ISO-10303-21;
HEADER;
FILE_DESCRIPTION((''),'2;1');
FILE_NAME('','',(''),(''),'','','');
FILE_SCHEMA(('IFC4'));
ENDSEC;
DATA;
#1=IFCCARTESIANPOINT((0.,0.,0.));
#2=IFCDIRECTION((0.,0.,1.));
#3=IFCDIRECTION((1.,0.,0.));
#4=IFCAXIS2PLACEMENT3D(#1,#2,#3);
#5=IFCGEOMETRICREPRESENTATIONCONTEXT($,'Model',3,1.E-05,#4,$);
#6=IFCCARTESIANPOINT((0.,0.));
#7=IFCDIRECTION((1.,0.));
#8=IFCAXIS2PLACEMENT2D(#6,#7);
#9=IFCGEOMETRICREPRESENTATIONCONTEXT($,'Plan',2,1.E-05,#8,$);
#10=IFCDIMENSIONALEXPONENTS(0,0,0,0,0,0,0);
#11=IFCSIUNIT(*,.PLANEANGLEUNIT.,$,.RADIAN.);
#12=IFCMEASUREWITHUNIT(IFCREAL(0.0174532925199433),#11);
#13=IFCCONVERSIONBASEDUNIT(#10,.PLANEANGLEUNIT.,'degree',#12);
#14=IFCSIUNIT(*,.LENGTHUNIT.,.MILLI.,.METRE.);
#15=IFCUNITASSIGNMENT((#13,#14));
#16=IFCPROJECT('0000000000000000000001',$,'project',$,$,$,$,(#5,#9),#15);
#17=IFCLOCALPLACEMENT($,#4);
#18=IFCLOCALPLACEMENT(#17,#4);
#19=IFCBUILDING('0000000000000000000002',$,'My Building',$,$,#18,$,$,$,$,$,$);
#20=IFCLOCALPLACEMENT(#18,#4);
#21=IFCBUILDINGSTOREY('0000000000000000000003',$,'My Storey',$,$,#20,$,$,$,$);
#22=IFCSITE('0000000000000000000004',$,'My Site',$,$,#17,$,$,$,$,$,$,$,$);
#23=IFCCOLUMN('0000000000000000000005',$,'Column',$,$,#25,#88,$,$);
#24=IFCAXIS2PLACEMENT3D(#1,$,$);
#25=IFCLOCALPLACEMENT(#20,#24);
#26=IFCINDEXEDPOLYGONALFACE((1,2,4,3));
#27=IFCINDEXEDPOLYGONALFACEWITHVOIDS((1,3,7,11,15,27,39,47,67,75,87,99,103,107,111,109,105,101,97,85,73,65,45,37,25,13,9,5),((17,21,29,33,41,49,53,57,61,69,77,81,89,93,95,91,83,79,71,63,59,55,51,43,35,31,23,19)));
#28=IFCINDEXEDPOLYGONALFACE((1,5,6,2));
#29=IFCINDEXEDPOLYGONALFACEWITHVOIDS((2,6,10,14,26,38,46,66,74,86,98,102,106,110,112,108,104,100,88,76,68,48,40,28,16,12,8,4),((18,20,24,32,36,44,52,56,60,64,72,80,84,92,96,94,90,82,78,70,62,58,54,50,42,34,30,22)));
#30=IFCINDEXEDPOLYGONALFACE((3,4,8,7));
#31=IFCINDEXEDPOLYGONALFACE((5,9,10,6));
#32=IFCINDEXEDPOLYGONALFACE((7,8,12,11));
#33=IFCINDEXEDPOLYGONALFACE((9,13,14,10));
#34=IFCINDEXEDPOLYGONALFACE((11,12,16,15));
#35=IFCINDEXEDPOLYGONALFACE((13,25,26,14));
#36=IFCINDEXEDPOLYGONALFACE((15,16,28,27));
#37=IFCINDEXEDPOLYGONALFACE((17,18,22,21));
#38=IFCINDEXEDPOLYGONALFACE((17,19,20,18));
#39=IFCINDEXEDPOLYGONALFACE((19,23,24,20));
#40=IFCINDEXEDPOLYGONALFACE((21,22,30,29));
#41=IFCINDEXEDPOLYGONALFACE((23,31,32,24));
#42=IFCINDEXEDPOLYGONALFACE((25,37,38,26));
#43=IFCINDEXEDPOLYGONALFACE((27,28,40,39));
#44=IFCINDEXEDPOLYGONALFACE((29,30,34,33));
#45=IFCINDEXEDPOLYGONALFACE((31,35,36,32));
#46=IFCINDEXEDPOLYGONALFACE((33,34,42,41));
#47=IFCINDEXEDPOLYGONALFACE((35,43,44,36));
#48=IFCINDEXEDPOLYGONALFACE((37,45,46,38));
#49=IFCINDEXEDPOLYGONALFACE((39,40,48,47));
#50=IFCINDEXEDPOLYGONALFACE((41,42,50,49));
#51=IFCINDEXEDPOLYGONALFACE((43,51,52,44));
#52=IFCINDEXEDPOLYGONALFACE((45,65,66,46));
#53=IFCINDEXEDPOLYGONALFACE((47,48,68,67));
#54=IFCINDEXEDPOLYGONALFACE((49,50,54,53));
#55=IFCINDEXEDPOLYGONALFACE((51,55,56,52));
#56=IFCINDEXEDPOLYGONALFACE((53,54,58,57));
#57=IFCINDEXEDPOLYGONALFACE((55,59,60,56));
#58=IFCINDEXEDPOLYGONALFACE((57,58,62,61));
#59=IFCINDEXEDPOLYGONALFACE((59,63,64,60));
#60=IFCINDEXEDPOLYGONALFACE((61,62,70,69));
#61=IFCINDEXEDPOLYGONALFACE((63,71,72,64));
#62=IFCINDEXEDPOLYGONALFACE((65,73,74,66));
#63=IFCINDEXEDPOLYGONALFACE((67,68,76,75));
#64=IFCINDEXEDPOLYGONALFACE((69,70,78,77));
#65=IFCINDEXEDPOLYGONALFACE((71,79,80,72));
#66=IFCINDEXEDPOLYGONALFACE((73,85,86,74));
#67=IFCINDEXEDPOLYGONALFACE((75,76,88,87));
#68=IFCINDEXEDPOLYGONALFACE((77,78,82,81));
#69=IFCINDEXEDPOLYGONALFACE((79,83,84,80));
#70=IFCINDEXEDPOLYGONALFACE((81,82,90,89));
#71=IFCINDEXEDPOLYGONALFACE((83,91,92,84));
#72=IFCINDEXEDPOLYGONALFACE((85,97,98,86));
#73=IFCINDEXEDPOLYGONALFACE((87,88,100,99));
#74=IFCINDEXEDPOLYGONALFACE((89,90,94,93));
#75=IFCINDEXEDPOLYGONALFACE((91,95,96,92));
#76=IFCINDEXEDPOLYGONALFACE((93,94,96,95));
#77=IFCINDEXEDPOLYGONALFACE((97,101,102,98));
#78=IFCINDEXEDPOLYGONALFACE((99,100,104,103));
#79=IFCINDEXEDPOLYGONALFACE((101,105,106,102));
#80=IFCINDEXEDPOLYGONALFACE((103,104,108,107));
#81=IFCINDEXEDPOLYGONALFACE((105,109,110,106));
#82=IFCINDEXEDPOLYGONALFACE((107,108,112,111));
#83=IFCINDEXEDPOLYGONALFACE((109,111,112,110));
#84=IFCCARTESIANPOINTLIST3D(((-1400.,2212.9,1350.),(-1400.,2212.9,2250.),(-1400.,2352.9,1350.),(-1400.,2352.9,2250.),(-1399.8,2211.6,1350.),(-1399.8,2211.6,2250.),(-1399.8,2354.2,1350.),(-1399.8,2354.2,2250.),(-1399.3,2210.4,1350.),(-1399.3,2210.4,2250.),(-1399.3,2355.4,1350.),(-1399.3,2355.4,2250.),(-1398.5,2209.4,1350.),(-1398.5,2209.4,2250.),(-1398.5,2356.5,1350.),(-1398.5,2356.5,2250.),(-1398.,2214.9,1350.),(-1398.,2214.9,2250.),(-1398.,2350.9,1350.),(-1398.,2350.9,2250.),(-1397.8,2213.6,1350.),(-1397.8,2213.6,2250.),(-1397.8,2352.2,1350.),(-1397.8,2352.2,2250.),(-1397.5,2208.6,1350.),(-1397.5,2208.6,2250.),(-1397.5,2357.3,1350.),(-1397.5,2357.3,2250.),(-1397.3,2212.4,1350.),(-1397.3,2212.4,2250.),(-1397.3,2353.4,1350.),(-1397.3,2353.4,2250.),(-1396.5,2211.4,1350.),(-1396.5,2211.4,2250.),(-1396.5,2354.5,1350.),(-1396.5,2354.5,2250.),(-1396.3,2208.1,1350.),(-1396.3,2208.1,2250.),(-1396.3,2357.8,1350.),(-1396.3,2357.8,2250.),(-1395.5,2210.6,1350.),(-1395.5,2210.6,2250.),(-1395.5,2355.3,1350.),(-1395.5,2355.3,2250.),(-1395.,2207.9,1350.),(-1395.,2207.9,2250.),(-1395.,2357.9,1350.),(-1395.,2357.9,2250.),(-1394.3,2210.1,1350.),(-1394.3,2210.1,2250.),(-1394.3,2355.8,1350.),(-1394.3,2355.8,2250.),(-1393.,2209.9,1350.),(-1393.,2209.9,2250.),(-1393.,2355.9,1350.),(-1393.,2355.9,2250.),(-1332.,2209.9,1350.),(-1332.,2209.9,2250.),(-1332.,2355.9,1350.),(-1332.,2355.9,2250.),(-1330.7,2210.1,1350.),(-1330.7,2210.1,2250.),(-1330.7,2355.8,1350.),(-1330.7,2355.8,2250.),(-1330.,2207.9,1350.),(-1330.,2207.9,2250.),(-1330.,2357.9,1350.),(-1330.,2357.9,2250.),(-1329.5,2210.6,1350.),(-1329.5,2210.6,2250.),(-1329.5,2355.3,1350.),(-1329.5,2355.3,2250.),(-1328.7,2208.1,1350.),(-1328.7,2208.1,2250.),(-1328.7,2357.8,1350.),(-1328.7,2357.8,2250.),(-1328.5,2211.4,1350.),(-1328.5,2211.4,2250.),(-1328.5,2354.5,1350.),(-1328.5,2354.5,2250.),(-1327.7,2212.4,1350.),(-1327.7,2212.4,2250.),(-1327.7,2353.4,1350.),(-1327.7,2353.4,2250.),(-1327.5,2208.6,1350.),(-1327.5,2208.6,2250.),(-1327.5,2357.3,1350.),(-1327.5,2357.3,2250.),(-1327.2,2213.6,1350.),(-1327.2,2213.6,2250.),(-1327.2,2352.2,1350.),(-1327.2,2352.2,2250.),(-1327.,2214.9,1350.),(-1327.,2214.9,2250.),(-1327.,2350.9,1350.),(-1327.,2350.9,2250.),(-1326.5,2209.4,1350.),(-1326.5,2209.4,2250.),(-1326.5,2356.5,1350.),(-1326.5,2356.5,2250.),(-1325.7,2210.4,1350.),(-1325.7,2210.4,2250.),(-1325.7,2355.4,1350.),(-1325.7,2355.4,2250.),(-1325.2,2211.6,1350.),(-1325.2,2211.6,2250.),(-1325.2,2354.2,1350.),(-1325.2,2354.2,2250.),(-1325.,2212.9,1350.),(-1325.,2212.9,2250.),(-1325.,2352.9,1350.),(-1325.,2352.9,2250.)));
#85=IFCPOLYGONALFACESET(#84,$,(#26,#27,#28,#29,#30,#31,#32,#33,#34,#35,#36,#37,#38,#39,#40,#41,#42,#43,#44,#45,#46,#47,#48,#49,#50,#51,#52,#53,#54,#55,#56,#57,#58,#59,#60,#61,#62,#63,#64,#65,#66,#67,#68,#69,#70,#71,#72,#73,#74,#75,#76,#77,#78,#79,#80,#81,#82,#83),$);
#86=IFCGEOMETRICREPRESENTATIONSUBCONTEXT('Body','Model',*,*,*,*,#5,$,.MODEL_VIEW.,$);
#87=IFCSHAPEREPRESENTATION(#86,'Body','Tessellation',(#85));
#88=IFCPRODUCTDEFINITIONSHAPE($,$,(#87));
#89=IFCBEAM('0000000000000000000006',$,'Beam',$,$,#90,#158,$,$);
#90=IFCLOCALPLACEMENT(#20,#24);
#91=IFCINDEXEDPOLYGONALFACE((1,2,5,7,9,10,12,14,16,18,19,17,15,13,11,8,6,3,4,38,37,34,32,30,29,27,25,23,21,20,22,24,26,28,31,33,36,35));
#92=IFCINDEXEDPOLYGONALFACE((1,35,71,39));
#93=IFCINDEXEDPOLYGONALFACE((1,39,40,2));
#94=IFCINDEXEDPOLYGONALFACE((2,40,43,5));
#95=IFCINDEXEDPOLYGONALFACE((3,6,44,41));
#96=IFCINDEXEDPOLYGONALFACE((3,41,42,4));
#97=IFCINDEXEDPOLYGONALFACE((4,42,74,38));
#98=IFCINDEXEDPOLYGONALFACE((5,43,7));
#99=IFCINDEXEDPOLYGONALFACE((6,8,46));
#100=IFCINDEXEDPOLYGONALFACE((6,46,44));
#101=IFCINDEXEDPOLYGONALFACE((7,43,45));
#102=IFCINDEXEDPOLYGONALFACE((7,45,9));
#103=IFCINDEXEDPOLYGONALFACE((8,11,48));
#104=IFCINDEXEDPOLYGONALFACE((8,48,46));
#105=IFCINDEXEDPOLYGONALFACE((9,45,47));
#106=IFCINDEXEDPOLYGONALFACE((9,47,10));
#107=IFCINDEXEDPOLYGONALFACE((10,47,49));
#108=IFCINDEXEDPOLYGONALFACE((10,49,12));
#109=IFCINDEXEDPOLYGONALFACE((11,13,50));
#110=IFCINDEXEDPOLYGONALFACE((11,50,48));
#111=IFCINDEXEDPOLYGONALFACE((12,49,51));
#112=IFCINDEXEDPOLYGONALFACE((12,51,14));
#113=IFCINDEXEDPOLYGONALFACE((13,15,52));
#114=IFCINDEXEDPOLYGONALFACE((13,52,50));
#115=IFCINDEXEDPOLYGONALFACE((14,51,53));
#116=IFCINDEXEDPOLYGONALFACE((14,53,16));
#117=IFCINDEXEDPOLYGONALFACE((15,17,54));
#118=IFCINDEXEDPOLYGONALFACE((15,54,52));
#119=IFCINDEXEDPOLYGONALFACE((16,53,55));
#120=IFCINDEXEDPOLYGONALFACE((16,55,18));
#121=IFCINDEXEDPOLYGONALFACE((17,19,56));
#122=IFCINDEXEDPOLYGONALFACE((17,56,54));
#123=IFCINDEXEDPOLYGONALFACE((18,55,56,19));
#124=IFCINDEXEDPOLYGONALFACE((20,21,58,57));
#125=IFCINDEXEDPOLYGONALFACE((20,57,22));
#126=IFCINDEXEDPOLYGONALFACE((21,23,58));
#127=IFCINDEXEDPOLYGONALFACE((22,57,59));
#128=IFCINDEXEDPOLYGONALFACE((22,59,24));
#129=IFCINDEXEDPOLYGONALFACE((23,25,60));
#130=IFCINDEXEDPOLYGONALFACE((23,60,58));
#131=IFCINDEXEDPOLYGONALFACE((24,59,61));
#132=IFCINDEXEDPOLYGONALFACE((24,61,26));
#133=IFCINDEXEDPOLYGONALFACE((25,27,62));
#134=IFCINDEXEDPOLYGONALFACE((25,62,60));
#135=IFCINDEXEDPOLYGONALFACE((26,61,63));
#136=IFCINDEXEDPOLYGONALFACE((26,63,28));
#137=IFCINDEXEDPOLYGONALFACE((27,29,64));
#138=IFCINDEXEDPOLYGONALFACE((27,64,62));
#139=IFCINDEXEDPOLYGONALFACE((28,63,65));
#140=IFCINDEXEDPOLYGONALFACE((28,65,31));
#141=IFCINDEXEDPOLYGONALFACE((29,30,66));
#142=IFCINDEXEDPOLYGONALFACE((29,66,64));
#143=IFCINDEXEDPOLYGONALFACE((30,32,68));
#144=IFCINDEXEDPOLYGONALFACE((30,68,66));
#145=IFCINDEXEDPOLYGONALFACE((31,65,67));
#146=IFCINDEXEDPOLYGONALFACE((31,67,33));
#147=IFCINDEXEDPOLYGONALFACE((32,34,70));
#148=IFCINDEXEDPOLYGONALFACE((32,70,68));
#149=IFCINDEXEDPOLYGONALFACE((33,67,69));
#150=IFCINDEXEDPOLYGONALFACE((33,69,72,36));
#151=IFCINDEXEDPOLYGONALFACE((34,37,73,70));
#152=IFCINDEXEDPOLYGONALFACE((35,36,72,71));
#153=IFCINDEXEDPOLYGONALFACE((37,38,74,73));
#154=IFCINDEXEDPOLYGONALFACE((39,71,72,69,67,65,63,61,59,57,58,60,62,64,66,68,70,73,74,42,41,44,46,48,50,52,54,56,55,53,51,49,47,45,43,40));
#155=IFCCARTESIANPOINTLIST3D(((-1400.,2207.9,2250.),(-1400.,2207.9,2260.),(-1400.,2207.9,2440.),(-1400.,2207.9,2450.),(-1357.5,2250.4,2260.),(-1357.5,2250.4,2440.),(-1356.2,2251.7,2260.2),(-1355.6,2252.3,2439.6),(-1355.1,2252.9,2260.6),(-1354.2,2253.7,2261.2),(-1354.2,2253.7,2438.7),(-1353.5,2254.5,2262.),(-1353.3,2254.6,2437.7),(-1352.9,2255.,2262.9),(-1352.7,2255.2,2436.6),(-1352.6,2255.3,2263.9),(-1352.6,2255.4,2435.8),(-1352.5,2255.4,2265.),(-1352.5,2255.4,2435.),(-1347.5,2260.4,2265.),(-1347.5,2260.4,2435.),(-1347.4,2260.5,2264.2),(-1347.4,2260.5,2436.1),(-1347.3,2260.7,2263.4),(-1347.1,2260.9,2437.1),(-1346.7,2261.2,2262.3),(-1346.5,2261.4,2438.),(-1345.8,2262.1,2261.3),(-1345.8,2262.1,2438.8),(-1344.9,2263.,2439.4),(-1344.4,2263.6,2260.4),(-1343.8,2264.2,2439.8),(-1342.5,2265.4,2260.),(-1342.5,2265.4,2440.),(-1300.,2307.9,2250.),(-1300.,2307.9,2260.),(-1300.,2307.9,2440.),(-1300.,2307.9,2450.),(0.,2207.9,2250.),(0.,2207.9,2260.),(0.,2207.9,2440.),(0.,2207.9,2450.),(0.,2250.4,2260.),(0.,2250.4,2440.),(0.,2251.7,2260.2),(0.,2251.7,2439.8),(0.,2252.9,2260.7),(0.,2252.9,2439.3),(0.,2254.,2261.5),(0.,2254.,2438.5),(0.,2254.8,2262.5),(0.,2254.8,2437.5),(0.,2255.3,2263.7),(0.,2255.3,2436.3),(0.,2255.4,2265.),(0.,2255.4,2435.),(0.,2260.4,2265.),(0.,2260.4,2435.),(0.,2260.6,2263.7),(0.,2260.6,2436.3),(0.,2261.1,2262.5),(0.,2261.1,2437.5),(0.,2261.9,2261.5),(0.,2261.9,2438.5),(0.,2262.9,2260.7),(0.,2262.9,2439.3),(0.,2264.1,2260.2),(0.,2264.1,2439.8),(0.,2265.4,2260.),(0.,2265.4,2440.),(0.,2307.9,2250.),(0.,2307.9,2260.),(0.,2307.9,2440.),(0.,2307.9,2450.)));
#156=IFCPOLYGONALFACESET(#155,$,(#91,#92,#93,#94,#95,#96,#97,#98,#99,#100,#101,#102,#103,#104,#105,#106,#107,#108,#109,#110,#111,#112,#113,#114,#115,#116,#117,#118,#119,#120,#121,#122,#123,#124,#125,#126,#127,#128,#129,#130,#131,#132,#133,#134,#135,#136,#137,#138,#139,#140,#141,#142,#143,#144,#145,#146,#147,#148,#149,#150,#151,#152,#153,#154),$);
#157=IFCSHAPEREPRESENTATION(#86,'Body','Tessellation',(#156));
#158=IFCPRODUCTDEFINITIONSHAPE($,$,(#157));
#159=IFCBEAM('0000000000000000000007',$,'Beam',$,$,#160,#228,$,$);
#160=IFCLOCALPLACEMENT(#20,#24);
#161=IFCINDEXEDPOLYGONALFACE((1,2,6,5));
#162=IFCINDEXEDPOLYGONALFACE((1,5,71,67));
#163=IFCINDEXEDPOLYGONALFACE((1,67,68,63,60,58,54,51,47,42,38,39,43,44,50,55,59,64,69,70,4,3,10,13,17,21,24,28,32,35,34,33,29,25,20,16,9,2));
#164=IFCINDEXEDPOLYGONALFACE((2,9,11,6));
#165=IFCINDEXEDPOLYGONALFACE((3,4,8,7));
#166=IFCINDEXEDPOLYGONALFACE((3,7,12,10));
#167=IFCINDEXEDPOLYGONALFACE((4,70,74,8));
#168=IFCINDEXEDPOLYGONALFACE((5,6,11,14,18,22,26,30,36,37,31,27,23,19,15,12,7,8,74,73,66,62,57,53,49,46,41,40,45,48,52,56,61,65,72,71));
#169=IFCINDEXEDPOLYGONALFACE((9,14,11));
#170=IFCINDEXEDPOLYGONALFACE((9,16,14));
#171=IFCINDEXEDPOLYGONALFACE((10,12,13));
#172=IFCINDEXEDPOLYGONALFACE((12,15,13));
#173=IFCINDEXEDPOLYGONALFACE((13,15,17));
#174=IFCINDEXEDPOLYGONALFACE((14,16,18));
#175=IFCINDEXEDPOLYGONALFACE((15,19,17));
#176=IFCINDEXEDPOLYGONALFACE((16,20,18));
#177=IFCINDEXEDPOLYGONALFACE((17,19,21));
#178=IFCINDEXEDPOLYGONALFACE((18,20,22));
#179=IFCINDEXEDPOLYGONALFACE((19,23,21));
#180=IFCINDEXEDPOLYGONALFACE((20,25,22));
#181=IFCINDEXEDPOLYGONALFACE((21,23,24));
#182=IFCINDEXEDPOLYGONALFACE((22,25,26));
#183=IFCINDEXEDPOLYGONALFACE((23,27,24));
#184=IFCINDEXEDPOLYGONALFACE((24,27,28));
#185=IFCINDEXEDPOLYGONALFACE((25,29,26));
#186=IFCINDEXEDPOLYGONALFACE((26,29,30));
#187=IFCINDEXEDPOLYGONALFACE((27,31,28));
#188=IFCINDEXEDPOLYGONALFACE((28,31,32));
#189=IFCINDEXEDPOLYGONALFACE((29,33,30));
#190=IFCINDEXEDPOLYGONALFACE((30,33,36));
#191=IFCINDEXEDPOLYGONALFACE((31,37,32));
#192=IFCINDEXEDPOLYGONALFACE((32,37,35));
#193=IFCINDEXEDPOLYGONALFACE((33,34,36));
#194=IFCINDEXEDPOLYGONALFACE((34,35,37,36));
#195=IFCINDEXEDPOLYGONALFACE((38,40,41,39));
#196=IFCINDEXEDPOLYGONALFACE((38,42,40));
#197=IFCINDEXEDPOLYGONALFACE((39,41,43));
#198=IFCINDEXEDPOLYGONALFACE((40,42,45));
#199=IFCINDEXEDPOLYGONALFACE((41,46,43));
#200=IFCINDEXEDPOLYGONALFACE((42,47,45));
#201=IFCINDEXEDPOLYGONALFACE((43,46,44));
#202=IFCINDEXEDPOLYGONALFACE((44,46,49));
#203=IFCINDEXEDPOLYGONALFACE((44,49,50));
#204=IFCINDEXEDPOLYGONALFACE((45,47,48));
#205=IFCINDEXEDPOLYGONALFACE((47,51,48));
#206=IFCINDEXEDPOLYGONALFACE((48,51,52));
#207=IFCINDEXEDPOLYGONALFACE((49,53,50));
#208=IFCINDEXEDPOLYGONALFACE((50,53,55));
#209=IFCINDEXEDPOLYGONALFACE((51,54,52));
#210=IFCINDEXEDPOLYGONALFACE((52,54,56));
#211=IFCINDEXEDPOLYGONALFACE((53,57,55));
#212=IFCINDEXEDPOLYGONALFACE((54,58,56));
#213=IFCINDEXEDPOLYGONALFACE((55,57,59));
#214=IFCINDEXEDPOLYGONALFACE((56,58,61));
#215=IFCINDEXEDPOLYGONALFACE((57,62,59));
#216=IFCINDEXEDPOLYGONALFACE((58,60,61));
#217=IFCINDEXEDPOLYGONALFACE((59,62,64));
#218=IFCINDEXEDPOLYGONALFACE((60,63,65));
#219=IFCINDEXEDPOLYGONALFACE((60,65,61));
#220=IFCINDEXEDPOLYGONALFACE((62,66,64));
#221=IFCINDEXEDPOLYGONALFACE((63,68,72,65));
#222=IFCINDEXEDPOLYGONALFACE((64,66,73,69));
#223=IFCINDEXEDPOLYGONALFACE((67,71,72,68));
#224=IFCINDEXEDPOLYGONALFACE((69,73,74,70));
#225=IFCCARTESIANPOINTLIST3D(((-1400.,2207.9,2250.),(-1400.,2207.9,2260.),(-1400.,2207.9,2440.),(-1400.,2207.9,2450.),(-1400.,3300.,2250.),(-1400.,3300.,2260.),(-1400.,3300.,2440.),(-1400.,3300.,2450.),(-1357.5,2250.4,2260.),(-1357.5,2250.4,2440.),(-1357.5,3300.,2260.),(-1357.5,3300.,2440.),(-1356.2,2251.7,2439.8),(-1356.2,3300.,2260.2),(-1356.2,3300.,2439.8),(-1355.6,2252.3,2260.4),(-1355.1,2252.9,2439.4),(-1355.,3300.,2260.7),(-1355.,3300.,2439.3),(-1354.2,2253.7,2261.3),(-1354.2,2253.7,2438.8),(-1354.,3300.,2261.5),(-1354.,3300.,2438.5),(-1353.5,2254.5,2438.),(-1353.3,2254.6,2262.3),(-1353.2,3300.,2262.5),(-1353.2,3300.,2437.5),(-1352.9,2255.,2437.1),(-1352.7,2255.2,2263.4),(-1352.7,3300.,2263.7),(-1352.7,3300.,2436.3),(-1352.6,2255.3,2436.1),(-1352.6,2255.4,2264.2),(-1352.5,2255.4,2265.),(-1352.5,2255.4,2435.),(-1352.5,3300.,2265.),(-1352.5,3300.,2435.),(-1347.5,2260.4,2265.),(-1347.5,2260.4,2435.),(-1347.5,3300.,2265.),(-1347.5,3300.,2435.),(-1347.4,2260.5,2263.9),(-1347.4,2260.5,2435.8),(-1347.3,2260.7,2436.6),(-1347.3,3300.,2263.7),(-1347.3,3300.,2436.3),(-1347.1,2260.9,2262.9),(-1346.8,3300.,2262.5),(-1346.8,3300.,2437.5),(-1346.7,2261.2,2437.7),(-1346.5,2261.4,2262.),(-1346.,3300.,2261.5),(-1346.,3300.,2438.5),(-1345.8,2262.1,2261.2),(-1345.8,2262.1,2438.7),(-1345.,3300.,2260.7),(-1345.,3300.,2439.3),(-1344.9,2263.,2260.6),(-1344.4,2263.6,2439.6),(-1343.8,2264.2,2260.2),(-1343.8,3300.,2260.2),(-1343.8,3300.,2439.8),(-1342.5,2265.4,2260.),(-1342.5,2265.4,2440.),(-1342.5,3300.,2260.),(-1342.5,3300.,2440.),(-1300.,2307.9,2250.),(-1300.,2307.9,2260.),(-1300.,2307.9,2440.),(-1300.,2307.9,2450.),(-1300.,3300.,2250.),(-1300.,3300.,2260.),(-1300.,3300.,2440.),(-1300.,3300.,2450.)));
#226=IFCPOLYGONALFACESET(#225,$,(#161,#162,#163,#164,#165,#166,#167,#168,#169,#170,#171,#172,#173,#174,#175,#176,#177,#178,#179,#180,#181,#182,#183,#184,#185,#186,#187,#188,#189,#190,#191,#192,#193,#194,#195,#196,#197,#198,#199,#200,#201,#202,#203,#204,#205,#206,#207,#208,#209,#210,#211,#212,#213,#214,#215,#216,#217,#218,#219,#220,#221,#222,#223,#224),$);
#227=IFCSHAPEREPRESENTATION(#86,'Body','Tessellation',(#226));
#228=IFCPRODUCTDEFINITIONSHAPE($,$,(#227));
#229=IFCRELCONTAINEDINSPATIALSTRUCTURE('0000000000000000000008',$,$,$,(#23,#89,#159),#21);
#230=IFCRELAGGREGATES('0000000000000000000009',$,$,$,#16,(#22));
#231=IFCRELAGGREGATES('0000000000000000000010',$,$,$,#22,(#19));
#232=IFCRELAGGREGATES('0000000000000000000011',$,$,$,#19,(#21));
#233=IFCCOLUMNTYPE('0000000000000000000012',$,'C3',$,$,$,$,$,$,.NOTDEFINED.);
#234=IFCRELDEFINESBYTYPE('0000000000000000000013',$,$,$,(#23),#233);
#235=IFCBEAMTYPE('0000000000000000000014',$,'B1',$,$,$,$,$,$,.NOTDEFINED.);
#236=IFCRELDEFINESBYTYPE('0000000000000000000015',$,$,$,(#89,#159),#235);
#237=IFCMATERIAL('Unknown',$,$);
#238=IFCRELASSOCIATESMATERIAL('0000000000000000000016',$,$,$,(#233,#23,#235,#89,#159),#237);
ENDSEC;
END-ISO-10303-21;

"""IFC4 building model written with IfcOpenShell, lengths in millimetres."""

from ifc_helpers import new_model, entity, si_unit, converted_unit, frame, origin_with_axes, origin_2d_with_axis, place, context, subcontext, project, spatial, hollow_rectangle, i_section, extrude, clip, halfspace, material, material_profile, profile_set, profile_usage, type_object, element, save


model = new_model("IFC4")

# Units and contexts
model_context = context("Model", 3, precision=1e-05, world=origin_with_axes())
plan_context = context("Plan", 2, precision=1e-05, world=origin_2d_with_axis())
body_context = subcontext(model_context, "Body", "Model", "MODEL_VIEW")
ifc_project = project(units=[converted_unit("PLANEANGLEUNIT", "degree", entity("IfcReal", 0.0174532925199433), si_unit("PLANEANGLEUNIT", "RADIAN"), dimensions=[0, 0, 0, 0, 0, 0, 0]), si_unit("LENGTHUNIT", "METRE", prefix="MILLI")], contexts=[model_context, plan_context])

# Site, building, storey
site_placement = place(None, origin_with_axes())
site = spatial("IfcSite", under=ifc_project, at=site_placement, Name="My Site")
building_placement = place(site_placement, origin_with_axes())
building = spatial("IfcBuilding", under=site, at=building_placement, Name="My Building")
storey_placement = place(building_placement, origin_with_axes())
storey = spatial("IfcBuildingStorey", under=building, at=storey_placement, Name="My Storey")

# Column
ifc_material = material(Name="Unknown")
ifc_material_profile_1 = material_profile(ifc_material, hollow_rectangle(XDim=75.0, YDim=150.0, WallThickness=2.0, InnerFilletRadius=5.0, OuterFilletRadius=5.0))
ifc_profile_set_1 = profile_set([ifc_material_profile_1])
ifc_profile_usage_1 = profile_usage(ifc_profile_set_1, cardinal=5)
column_type = type_object("IfcColumnType", Name="C3", PredefinedType="NOTDEFINED", material=ifc_profile_set_1)
column_placement = place(storey_placement, frame((-1362.5, 2282.9, 1350.0), z_axis=(0.0, 0.0, 1.0), x_axis=(1.0, 0.0, 0.0)))
element("IfcColumn", 1, at=column_placement, inside=storey, type_object=column_type, material=ifc_profile_usage_1, Name="Column", context=body_context, shape_type="SweptSolid", body=[
    extrude(hollow_rectangle(XDim=75.0, YDim=150.0, WallThickness=2.0, InnerFilletRadius=5.0, OuterFilletRadius=5.0), origin_with_axes(), (0.0, 0.0, 1.0), 900.0),
])

# Beams
ifc_material_profile_2 = material_profile(ifc_material, i_section(OverallWidth=100.0, OverallDepth=200.0, WebThickness=5.0, FlangeThickness=10.0, FilletRadius=5.0))
ifc_profile_set_2 = profile_set([ifc_material_profile_2])
ifc_profile_usage_2 = profile_usage(ifc_profile_set_2, cardinal=5)
beam_type_1 = type_object("IfcBeamType", Name="B1", PredefinedType="NOTDEFINED", material=ifc_profile_set_2)
beam_1_placement = place(storey_placement, frame((-1400.0, 2257.9, 2350.0), z_axis=(1.0, 0.0, 0.0), x_axis=(0.0, 1.0, 0.0)))
element("IfcBeam", 2, at=beam_1_placement, inside=storey, type_object=beam_type_1, material=ifc_profile_usage_2, Name="Beam", context=body_context, shape_type="Clipping", body=[
    clip(extrude(i_section(OverallWidth=100.0, OverallDepth=200.0, WebThickness=5.0, FlangeThickness=10.0, FilletRadius=5.0), origin_with_axes(), (0.0, 0.0, 1.0), 1400.0), halfspace(frame((-50.0, -2350.0, 0.0), z_axis=(0.707107, 0.0, -0.707107), x_axis=(0.0, -1.0, 0.0)), False)),
])
ifc_profile_usage_3 = profile_usage(ifc_profile_set_2, cardinal=5)
beam_2_placement = place(storey_placement, frame((-1350.0, 2207.9, 2350.0), z_axis=(0.0, 1.0, 0.0), x_axis=(-1.0, 0.0, 0.0)))
element("IfcBeam", 3, at=beam_2_placement, inside=storey, type_object=beam_type_1, material=ifc_profile_usage_3, Name="Beam", context=body_context, shape_type="Clipping", body=[
    clip(extrude(i_section(OverallWidth=100.0, OverallDepth=200.0, WebThickness=5.0, FlangeThickness=10.0, FilletRadius=5.0), origin_with_axes(), (0.0, 0.0, 1.0), 1092.1), halfspace(frame((50.0, -2350.0, 0.0), z_axis=(-0.707107, 0.0, -0.707107), x_axis=(0.0, 1.0, 0.0)), False)),
])

save(model, "model.ifc")
